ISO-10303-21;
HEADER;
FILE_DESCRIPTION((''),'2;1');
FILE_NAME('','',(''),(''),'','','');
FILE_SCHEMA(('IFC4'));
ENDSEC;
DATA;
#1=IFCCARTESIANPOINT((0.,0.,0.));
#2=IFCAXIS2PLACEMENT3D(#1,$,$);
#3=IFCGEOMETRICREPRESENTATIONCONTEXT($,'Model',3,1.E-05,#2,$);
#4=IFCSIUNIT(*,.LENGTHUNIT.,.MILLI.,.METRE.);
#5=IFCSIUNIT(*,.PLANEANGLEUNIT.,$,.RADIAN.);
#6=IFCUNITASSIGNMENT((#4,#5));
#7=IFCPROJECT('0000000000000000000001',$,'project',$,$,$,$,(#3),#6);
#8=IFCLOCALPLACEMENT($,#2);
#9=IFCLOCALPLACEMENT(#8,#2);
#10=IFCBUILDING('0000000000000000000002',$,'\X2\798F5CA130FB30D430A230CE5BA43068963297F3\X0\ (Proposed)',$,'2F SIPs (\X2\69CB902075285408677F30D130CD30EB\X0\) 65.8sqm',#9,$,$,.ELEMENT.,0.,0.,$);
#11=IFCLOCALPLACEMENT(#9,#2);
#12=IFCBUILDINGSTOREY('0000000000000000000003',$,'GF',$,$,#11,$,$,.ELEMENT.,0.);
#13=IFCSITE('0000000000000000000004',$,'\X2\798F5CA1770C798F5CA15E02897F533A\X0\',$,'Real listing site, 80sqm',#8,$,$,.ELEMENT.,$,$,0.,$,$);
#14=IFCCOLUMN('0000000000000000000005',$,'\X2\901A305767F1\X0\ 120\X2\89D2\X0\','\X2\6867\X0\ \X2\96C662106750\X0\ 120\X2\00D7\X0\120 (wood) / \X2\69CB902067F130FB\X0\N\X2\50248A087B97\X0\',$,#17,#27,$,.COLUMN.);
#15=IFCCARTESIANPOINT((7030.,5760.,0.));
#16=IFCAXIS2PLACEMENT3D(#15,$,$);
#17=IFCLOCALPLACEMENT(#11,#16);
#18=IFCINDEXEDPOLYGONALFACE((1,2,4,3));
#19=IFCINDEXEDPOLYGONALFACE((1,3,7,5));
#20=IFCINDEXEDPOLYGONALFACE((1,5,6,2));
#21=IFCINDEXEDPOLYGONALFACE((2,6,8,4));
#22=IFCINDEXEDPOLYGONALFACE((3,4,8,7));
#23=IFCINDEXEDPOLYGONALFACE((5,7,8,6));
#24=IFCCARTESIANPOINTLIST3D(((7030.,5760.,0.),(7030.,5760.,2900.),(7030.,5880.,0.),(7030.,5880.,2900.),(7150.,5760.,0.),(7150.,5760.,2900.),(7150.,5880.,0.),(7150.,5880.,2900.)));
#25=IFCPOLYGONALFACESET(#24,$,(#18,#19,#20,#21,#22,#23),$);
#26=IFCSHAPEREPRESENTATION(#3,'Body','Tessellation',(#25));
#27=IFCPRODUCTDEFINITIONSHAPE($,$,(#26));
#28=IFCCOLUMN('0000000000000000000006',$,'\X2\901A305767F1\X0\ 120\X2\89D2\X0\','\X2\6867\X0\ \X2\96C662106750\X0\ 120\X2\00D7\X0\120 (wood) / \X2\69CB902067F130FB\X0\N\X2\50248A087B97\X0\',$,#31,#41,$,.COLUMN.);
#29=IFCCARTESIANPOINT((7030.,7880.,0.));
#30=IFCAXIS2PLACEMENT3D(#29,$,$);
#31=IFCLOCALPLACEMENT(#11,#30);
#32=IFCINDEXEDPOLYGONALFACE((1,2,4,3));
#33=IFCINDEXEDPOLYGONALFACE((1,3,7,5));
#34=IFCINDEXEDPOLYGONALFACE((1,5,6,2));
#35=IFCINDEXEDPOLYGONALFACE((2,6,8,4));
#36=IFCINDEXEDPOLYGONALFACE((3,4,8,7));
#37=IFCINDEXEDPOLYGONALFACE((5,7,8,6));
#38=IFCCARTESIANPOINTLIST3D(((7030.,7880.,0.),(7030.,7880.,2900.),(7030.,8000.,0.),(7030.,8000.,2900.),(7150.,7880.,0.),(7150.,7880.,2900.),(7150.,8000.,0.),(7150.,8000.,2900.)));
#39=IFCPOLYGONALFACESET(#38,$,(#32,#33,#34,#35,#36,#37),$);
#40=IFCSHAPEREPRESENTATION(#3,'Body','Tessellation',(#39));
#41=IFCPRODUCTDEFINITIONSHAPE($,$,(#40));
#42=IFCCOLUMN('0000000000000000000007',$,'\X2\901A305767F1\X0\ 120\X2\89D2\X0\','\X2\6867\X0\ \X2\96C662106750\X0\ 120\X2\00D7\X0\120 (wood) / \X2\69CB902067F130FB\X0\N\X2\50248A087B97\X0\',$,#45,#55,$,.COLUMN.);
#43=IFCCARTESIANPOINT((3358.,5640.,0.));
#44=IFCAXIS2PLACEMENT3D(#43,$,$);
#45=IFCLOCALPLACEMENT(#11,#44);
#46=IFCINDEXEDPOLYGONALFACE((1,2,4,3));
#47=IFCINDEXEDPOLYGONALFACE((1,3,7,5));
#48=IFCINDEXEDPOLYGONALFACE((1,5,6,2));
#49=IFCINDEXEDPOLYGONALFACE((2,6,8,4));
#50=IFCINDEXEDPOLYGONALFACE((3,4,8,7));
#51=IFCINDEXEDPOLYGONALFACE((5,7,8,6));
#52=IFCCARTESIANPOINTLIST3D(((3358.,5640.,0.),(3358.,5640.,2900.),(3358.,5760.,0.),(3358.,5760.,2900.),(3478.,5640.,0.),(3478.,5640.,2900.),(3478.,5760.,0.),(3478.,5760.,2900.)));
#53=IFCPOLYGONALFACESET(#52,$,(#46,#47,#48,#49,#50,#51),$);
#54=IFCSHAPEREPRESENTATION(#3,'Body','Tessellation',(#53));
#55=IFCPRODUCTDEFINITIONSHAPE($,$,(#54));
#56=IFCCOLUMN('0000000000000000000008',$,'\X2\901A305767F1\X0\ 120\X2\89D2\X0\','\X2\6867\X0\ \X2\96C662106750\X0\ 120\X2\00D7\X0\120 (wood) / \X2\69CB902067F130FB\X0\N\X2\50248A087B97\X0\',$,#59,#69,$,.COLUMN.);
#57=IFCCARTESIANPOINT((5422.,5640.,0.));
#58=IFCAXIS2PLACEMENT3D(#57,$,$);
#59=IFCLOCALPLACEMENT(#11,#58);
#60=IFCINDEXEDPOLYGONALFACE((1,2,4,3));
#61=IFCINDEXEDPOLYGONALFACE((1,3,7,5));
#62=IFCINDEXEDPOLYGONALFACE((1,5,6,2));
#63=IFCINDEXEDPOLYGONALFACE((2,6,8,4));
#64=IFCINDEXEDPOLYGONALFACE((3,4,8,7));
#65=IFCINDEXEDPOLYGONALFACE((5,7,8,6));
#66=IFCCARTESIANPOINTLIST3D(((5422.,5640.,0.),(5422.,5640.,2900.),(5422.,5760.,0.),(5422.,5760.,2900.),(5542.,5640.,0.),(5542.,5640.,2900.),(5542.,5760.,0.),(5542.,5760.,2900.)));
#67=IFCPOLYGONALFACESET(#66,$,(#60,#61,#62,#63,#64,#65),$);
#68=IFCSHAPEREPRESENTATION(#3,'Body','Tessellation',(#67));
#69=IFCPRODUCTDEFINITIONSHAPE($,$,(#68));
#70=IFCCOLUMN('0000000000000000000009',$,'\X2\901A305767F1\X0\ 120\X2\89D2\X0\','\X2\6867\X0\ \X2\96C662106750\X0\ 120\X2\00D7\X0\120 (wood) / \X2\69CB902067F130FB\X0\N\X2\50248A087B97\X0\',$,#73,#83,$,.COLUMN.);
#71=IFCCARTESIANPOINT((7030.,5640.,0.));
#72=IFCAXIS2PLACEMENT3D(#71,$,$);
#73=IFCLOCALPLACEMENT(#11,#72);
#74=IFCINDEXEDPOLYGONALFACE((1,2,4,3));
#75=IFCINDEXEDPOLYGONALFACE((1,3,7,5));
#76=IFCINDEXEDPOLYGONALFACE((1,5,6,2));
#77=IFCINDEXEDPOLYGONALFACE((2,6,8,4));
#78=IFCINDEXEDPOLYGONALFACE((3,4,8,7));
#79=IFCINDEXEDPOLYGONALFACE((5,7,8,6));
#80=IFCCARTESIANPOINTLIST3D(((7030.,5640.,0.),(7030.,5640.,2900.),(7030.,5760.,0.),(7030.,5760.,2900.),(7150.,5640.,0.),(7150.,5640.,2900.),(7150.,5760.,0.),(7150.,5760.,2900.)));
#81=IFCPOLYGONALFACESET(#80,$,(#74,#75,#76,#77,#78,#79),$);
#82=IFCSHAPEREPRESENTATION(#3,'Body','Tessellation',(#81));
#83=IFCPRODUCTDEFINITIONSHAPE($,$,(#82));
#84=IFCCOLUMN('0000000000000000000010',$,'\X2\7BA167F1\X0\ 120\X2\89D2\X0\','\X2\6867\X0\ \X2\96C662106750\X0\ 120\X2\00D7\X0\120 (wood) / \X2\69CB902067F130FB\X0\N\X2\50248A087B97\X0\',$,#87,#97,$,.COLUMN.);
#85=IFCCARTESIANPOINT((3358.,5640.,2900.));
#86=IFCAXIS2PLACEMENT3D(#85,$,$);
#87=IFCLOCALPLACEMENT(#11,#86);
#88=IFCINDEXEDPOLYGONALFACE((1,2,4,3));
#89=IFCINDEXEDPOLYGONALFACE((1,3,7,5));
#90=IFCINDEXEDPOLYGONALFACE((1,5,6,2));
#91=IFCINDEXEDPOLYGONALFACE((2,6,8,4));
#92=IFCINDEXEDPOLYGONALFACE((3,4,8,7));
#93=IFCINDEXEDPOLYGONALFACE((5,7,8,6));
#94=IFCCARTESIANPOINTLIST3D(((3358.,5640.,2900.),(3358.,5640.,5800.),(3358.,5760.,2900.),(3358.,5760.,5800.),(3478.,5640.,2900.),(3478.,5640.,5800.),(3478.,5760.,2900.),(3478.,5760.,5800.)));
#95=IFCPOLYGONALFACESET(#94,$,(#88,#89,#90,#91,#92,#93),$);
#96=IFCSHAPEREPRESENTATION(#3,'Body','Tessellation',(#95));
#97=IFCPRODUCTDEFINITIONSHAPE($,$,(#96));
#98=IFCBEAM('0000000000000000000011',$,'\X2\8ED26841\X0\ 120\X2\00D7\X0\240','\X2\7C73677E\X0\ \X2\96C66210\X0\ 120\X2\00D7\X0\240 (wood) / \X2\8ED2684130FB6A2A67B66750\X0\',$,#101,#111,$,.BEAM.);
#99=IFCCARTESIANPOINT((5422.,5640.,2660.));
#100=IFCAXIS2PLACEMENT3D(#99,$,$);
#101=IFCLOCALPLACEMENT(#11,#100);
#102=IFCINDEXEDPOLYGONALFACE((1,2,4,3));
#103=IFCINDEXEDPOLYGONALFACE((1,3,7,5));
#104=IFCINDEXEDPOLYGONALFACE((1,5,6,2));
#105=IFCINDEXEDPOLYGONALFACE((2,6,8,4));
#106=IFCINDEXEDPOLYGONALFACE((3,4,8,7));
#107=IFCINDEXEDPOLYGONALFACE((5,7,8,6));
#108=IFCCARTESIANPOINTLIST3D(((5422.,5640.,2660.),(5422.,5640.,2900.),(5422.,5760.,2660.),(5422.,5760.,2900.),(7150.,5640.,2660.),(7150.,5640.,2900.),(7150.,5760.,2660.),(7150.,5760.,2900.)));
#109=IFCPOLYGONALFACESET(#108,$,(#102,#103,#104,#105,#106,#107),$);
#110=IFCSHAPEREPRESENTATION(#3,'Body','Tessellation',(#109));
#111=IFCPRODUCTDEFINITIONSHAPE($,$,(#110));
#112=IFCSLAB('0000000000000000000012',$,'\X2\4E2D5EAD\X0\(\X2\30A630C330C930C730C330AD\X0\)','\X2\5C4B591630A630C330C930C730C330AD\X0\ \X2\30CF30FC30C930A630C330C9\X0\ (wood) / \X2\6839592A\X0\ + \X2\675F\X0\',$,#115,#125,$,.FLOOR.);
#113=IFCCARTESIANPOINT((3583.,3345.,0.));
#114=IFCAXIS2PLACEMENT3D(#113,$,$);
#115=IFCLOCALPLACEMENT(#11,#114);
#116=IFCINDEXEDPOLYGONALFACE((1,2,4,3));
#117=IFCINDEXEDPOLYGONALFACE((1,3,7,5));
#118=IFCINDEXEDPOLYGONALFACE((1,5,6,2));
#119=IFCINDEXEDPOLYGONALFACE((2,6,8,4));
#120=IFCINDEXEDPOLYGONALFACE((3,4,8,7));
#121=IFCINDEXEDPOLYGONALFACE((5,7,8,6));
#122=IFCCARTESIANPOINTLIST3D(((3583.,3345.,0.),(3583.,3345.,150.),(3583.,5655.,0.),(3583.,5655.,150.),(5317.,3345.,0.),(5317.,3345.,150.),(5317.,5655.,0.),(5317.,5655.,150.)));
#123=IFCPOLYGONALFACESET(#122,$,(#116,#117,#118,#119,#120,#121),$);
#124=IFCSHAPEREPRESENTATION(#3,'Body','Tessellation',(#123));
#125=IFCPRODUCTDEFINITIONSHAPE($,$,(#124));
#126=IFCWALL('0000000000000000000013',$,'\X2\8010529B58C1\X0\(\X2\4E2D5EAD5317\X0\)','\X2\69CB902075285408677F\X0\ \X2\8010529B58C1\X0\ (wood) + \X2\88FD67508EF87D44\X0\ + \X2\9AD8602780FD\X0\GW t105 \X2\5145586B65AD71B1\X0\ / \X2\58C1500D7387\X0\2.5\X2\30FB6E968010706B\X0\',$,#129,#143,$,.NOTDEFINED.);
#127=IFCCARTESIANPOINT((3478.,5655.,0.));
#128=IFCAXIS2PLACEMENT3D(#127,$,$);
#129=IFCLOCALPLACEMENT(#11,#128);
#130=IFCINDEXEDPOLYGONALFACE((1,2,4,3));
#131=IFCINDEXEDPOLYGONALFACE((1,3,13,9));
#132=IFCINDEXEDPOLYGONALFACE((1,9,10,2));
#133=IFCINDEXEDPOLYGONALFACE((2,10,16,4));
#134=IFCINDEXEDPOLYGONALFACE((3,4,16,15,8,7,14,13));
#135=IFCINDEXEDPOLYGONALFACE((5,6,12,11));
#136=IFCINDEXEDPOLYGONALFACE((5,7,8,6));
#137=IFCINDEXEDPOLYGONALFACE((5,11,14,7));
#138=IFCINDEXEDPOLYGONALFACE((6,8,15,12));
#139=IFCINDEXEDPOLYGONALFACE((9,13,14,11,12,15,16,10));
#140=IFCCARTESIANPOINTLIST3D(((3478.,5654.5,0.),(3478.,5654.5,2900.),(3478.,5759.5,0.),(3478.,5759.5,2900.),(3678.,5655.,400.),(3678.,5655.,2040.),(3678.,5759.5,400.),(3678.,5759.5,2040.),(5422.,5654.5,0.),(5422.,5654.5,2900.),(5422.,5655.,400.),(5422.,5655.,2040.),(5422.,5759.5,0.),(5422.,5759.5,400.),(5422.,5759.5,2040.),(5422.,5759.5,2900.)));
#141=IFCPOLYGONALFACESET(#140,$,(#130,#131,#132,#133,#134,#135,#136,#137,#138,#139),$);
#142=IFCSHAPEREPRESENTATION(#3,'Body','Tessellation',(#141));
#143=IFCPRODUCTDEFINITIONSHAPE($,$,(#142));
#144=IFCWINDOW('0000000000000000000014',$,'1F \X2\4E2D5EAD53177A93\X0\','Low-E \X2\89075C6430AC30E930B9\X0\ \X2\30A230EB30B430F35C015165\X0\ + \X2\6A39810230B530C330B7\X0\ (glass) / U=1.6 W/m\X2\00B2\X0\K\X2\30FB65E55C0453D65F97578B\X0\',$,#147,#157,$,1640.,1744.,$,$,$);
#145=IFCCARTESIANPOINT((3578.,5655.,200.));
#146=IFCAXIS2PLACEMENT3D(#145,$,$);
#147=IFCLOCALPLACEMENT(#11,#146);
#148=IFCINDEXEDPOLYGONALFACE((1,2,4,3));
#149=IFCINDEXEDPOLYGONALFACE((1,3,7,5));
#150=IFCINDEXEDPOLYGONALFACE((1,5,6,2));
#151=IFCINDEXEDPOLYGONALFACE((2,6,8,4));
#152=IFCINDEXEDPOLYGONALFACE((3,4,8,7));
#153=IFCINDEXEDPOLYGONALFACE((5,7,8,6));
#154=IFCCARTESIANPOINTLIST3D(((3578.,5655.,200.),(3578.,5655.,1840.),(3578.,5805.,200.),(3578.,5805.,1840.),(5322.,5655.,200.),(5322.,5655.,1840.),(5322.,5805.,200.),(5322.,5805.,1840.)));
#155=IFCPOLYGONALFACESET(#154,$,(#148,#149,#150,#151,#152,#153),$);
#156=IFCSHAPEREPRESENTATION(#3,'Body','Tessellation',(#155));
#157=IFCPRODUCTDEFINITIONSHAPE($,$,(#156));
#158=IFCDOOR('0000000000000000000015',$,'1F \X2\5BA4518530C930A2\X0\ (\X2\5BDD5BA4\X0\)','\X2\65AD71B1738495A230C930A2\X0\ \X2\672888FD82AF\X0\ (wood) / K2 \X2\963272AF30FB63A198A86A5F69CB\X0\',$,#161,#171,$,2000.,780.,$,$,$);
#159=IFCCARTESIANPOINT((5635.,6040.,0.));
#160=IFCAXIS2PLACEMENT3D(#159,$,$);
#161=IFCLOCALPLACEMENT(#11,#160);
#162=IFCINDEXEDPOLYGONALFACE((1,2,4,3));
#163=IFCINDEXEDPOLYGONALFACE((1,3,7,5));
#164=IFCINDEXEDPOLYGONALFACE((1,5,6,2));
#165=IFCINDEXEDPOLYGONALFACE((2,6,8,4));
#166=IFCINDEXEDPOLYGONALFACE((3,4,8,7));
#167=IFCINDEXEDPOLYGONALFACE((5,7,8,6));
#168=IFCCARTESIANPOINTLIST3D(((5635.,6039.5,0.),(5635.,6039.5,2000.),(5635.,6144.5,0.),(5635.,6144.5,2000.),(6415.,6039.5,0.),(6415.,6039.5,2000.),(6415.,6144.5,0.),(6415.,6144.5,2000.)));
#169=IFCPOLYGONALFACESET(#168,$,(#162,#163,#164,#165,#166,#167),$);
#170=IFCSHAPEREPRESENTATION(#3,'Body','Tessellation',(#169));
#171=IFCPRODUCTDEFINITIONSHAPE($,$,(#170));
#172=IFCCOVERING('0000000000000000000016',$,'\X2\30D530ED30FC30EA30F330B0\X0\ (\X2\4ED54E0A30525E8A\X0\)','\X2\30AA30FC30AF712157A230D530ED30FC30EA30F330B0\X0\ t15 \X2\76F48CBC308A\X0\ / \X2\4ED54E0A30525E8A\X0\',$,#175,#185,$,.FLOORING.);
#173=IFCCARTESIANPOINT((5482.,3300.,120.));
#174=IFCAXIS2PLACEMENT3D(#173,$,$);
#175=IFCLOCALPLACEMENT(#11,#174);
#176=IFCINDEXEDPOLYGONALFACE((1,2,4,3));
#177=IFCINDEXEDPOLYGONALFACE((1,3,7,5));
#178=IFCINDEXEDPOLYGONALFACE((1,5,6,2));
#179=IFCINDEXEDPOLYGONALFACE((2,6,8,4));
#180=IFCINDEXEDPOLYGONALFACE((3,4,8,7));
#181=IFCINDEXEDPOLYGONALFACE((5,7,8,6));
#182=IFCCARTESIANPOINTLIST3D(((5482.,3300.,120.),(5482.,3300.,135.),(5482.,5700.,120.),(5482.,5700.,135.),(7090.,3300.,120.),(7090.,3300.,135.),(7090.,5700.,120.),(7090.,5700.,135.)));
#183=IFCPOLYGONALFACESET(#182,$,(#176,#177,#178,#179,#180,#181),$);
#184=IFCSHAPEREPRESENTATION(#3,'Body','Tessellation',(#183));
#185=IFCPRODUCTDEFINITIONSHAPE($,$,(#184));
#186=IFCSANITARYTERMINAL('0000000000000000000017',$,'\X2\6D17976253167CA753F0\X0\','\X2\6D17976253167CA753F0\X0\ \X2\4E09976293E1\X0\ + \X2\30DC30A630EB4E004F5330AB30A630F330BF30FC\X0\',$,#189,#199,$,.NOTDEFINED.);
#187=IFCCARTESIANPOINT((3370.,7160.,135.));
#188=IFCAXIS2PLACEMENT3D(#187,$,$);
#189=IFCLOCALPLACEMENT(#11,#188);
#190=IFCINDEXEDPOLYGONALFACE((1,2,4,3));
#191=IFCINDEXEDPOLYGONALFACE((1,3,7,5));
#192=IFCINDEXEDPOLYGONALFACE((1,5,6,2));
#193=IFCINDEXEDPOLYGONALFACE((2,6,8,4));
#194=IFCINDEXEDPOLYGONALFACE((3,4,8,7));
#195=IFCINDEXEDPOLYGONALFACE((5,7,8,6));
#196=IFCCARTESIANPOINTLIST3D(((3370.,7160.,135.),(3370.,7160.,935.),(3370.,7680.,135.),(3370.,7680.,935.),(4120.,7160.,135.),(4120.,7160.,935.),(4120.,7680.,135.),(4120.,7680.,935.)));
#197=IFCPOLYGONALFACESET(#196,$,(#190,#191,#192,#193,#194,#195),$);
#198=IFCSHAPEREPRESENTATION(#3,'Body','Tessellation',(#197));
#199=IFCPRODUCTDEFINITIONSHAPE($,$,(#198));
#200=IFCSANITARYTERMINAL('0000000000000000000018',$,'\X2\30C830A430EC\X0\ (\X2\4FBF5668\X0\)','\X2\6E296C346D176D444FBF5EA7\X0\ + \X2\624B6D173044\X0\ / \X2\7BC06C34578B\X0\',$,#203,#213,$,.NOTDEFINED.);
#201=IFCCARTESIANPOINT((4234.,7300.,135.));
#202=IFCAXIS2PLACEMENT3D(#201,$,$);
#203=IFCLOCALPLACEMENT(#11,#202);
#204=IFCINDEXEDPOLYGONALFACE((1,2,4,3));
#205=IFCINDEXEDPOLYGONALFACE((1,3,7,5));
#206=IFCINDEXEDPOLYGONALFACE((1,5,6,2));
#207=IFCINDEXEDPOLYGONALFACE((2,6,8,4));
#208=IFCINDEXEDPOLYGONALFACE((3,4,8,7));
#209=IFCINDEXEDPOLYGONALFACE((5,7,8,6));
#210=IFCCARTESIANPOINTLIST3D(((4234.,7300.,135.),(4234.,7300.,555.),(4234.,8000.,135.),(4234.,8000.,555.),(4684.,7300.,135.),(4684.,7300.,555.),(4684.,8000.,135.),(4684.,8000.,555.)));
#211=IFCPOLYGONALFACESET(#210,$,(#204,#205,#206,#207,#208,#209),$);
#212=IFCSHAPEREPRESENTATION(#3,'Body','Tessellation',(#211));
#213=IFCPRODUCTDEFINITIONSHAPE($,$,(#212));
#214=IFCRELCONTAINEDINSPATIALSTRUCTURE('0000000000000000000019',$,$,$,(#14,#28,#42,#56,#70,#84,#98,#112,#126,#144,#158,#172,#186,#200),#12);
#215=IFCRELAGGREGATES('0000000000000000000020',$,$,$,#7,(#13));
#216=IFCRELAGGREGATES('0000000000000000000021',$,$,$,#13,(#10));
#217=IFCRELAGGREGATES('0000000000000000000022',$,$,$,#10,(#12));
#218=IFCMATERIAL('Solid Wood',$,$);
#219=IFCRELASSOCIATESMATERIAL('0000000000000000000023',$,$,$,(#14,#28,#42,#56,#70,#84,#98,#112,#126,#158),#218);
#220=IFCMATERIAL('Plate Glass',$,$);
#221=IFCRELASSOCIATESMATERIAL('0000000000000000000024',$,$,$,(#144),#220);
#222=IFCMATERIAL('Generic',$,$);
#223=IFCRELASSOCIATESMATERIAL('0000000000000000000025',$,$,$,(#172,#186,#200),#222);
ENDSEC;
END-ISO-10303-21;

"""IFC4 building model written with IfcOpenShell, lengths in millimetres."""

from ifc_helpers import new_model, si_unit, frame, frame_2d, origin, place, context, project, spatial, rectangle, extrude, material, element, fill, save


model = new_model("IFC4")

# Units and contexts
model_context = context("Model", 3, precision=1e-05, world=origin())
ifc_project = project(units=[si_unit("LENGTHUNIT", "METRE", prefix="MILLI"), si_unit("PLANEANGLEUNIT", "RADIAN")], contexts=[model_context])

# Site, building, storey
site_placement = place(None, origin())
site = spatial("IfcSite", under=ifc_project, at=site_placement, Name="福岡県福岡市西区", ObjectType="Real listing site, 80sqm", CompositionType="ELEMENT", RefElevation=0.0)
building_placement = place(site_placement, origin())
building = spatial("IfcBuilding", under=site, at=building_placement, Name="福岡・ピアノ室と防音 (Proposed)", ObjectType="2F SIPs (構造用合板パネル) 65.8sqm", CompositionType="ELEMENT", ElevationOfRefHeight=0.0, ElevationOfTerrain=0.0)
storey_placement = place(building_placement, origin())
storey = spatial("IfcBuildingStorey", under=building, at=storey_placement, Name="GF", CompositionType="ELEMENT", Elevation=0.0)

# Columns
ifc_material_1 = material(Name="Solid Wood")
column_1_placement = place(storey_placement, frame((7030.0, 5760.0, 0.0)))
element("IfcColumn", 1, at=column_1_placement, inside=storey, material=ifc_material_1, Name="通し柱 120角", Description="桧 集成材 120×120 (wood) / 構造柱・N値計算", PredefinedType="COLUMN", context=model_context, shape_type="SweptSolid", body=[
    extrude(rectangle(XDim=120.0, YDim=120.0, at=frame_2d((60.0, 60.0))), frame((7030.0, 5760.0, 0.0)), (0.0, 0.0, 1.0), 2900.0),
])
column_2_placement = place(storey_placement, frame((7030.0, 7880.0, 0.0)))
element("IfcColumn", 2, at=column_2_placement, inside=storey, material=ifc_material_1, Name="通し柱 120角", Description="桧 集成材 120×120 (wood) / 構造柱・N値計算", PredefinedType="COLUMN", context=model_context, shape_type="SweptSolid", body=[
    extrude(rectangle(XDim=120.0, YDim=120.0, at=frame_2d((60.0, 60.0))), frame((7030.0, 7880.0, 0.0)), (0.0, 0.0, 1.0), 2900.0),
])
column_3_placement = place(storey_placement, frame((3358.0, 5640.0, 0.0)))
element("IfcColumn", 3, at=column_3_placement, inside=storey, material=ifc_material_1, Name="通し柱 120角", Description="桧 集成材 120×120 (wood) / 構造柱・N値計算", PredefinedType="COLUMN", context=model_context, shape_type="SweptSolid", body=[
    extrude(rectangle(XDim=120.0, YDim=120.0, at=frame_2d((60.0, 60.0))), frame((3358.0, 5640.0, 0.0)), (0.0, 0.0, 1.0), 2900.0),
])
column_4_placement = place(storey_placement, frame((5422.0, 5640.0, 0.0)))
element("IfcColumn", 4, at=column_4_placement, inside=storey, material=ifc_material_1, Name="通し柱 120角", Description="桧 集成材 120×120 (wood) / 構造柱・N値計算", PredefinedType="COLUMN", context=model_context, shape_type="SweptSolid", body=[
    extrude(rectangle(XDim=120.0, YDim=120.0, at=frame_2d((60.0, 60.0))), frame((5422.0, 5640.0, 0.0)), (0.0, 0.0, 1.0), 2900.0),
])
column_5_placement = place(storey_placement, frame((7030.0, 5640.0, 0.0)))
element("IfcColumn", 5, at=column_5_placement, inside=storey, material=ifc_material_1, Name="通し柱 120角", Description="桧 集成材 120×120 (wood) / 構造柱・N値計算", PredefinedType="COLUMN", context=model_context, shape_type="SweptSolid", body=[
    extrude(rectangle(XDim=120.0, YDim=120.0, at=frame_2d((60.0, 60.0))), frame((7030.0, 5640.0, 0.0)), (0.0, 0.0, 1.0), 2900.0),
])
column_6_placement = place(storey_placement, frame((3358.0, 5640.0, 2900.0)))
element("IfcColumn", 6, at=column_6_placement, inside=storey, material=ifc_material_1, Name="管柱 120角", Description="桧 集成材 120×120 (wood) / 構造柱・N値計算", PredefinedType="COLUMN", context=model_context, shape_type="SweptSolid", body=[
    extrude(rectangle(XDim=120.0, YDim=120.0, at=frame_2d((60.0, 60.0))), frame((3358.0, 5640.0, 2900.0)), (0.0, 0.0, 1.0), 2900.0),
])

# Beam
beam_1_placement = place(storey_placement, frame((5422.0, 5640.0, 2660.0)))
element("IfcBeam", 7, at=beam_1_placement, inside=storey, material=ifc_material_1, Name="軒桁 120×240", Description="米松 集成 120×240 (wood) / 軒桁・横架材", PredefinedType="BEAM", context=model_context, shape_type="SweptSolid", body=[
    extrude(rectangle(XDim=1728.0, YDim=120.0, at=frame_2d((864.0, 60.0))), frame((5422.0, 5640.0, 2660.0)), (0.0, 0.0, 1.0), 240.0),
])

# Slab
slab_placement = place(storey_placement, frame((3583.0, 3345.0, 0.0)))
element("IfcSlab", 8, at=slab_placement, inside=storey, material=ifc_material_1, Name="中庭(ウッドデッキ)", Description="屋外ウッドデッキ ハードウッド (wood) / 根太 + 束", PredefinedType="FLOOR", context=model_context, shape_type="SweptSolid", body=[
    extrude(rectangle(XDim=1734.0, YDim=2310.0, at=frame_2d((867.0, 1155.0))), frame((3583.0, 3345.0, 0.0)), (0.0, 0.0, 1.0), 150.0),
])

# Wall, opening, window
wall_1_placement = place(storey_placement, frame((3478.0, 5655.0, 0.0)))
wall_1 = element("IfcWall", 9, at=wall_1_placement, inside=storey, material=ifc_material_1, Name="耐力壁(中庭北)", Description="構造用合板 耐力壁 (wood) + 製材軸組 + 高性能GW t105 充填断熱 / 壁倍率2.5・準耐火", PredefinedType="NOTDEFINED", context=model_context, shape_type="SweptSolid", body=[
    extrude(rectangle(XDim=1944.0, YDim=105.0, at=frame_2d((972.0, 52.0))), frame((3478.0, 5655.0, 0.0)), (0.0, 0.0, 1.0), 2900.0),
])
opening_placement = place(storey_placement, frame((3578.0, 5655.0, 200.0)))
opening = element("IfcOpeningElement", 10, at=opening_placement, cuts=wall_1, PredefinedType="NOTDEFINED", context=model_context, shape_type="SweptSolid", body=[
    extrude(rectangle(XDim=1744.0, YDim=150.0, at=frame_2d((872.0, 75.0))), frame((3578.0, 5655.0, 200.0)), (0.0, 0.0, 1.0), 1640.0),
])
ifc_material_2 = material(Name="Plate Glass")
window_placement = place(storey_placement, frame((3578.0, 5655.0, 200.0)))
window = element("IfcWindow", 11, at=window_placement, inside=storey, material=ifc_material_2, Name="1F 中庭北窓", Description="Low-E 複層ガラス アルゴン封入 + 樹脂サッシ (glass) / U=1.6 W/m²K・日射取得型", OverallHeight=1640.0, OverallWidth=1744.0, context=model_context, shape_type="SweptSolid", body=[
    extrude(rectangle(XDim=1744.0, YDim=150.0, at=frame_2d((872.0, 75.0))), frame((3578.0, 5655.0, 200.0)), (0.0, 0.0, 1.0), 1640.0),
])
fill(opening, window)

# Door
door_placement = place(storey_placement, frame((5635.0, 6040.0, 0.0)))
element("IfcDoor", 12, at=door_placement, inside=storey, material=ifc_material_1, Name="1F 室内ドア (寝室)", Description="断熱玄関ドア 木製芯 (wood) / K2 防犯・採風機構", OverallHeight=2000.0, OverallWidth=780.0, context=model_context, shape_type="SweptSolid", body=[
    extrude(rectangle(XDim=780.0, YDim=105.0, at=frame_2d((390.0, 52.0))), frame((5635.0, 6040.0, 0.0)), (0.0, 0.0, 1.0), 2000.0),
])

# Covering
ifc_material_3 = material(Name="Generic")
covering_placement = place(storey_placement, frame((5482.0, 3300.0, 120.0)))
element("IfcCovering", 13, at=covering_placement, inside=storey, material=ifc_material_3, Name="フローリング (仕上げ床)", Description="オーク無垢フローリング t15 直貼り / 仕上げ床", PredefinedType="FLOORING", context=model_context, shape_type="SweptSolid", body=[
    extrude(rectangle(XDim=1608.0, YDim=2400.0, at=frame_2d((804.0, 1200.0))), frame((5482.0, 3300.0, 120.0)), (0.0, 0.0, 1.0), 15.0),
])

# Sanitary terminals
sanitary_terminal_1_placement = place(storey_placement, frame((3370.0, 7160.0, 135.0)))
element("IfcSanitaryTerminal", 14, at=sanitary_terminal_1_placement, inside=storey, material=ifc_material_3, Name="洗面化粧台", Description="洗面化粧台 三面鏡 + ボウル一体カウンター", PredefinedType="NOTDEFINED", context=model_context, shape_type="SweptSolid", body=[
    extrude(rectangle(XDim=750.0, YDim=520.0, at=frame_2d((375.0, 260.0))), frame((3370.0, 7160.0, 135.0)), (0.0, 0.0, 1.0), 800.0),
])
sanitary_terminal_2_placement = place(storey_placement, frame((4234.0, 7300.0, 135.0)))
element("IfcSanitaryTerminal", 15, at=sanitary_terminal_2_placement, inside=storey, material=ifc_material_3, Name="トイレ (便器)", Description="温水洗浄便座 + 手洗い / 節水型", PredefinedType="NOTDEFINED", context=model_context, shape_type="SweptSolid", body=[
    extrude(rectangle(XDim=450.0, YDim=700.0, at=frame_2d((225.0, 350.0))), frame((4234.0, 7300.0, 135.0)), (0.0, 0.0, 1.0), 420.0),
])

save(model, "model.ifc")
